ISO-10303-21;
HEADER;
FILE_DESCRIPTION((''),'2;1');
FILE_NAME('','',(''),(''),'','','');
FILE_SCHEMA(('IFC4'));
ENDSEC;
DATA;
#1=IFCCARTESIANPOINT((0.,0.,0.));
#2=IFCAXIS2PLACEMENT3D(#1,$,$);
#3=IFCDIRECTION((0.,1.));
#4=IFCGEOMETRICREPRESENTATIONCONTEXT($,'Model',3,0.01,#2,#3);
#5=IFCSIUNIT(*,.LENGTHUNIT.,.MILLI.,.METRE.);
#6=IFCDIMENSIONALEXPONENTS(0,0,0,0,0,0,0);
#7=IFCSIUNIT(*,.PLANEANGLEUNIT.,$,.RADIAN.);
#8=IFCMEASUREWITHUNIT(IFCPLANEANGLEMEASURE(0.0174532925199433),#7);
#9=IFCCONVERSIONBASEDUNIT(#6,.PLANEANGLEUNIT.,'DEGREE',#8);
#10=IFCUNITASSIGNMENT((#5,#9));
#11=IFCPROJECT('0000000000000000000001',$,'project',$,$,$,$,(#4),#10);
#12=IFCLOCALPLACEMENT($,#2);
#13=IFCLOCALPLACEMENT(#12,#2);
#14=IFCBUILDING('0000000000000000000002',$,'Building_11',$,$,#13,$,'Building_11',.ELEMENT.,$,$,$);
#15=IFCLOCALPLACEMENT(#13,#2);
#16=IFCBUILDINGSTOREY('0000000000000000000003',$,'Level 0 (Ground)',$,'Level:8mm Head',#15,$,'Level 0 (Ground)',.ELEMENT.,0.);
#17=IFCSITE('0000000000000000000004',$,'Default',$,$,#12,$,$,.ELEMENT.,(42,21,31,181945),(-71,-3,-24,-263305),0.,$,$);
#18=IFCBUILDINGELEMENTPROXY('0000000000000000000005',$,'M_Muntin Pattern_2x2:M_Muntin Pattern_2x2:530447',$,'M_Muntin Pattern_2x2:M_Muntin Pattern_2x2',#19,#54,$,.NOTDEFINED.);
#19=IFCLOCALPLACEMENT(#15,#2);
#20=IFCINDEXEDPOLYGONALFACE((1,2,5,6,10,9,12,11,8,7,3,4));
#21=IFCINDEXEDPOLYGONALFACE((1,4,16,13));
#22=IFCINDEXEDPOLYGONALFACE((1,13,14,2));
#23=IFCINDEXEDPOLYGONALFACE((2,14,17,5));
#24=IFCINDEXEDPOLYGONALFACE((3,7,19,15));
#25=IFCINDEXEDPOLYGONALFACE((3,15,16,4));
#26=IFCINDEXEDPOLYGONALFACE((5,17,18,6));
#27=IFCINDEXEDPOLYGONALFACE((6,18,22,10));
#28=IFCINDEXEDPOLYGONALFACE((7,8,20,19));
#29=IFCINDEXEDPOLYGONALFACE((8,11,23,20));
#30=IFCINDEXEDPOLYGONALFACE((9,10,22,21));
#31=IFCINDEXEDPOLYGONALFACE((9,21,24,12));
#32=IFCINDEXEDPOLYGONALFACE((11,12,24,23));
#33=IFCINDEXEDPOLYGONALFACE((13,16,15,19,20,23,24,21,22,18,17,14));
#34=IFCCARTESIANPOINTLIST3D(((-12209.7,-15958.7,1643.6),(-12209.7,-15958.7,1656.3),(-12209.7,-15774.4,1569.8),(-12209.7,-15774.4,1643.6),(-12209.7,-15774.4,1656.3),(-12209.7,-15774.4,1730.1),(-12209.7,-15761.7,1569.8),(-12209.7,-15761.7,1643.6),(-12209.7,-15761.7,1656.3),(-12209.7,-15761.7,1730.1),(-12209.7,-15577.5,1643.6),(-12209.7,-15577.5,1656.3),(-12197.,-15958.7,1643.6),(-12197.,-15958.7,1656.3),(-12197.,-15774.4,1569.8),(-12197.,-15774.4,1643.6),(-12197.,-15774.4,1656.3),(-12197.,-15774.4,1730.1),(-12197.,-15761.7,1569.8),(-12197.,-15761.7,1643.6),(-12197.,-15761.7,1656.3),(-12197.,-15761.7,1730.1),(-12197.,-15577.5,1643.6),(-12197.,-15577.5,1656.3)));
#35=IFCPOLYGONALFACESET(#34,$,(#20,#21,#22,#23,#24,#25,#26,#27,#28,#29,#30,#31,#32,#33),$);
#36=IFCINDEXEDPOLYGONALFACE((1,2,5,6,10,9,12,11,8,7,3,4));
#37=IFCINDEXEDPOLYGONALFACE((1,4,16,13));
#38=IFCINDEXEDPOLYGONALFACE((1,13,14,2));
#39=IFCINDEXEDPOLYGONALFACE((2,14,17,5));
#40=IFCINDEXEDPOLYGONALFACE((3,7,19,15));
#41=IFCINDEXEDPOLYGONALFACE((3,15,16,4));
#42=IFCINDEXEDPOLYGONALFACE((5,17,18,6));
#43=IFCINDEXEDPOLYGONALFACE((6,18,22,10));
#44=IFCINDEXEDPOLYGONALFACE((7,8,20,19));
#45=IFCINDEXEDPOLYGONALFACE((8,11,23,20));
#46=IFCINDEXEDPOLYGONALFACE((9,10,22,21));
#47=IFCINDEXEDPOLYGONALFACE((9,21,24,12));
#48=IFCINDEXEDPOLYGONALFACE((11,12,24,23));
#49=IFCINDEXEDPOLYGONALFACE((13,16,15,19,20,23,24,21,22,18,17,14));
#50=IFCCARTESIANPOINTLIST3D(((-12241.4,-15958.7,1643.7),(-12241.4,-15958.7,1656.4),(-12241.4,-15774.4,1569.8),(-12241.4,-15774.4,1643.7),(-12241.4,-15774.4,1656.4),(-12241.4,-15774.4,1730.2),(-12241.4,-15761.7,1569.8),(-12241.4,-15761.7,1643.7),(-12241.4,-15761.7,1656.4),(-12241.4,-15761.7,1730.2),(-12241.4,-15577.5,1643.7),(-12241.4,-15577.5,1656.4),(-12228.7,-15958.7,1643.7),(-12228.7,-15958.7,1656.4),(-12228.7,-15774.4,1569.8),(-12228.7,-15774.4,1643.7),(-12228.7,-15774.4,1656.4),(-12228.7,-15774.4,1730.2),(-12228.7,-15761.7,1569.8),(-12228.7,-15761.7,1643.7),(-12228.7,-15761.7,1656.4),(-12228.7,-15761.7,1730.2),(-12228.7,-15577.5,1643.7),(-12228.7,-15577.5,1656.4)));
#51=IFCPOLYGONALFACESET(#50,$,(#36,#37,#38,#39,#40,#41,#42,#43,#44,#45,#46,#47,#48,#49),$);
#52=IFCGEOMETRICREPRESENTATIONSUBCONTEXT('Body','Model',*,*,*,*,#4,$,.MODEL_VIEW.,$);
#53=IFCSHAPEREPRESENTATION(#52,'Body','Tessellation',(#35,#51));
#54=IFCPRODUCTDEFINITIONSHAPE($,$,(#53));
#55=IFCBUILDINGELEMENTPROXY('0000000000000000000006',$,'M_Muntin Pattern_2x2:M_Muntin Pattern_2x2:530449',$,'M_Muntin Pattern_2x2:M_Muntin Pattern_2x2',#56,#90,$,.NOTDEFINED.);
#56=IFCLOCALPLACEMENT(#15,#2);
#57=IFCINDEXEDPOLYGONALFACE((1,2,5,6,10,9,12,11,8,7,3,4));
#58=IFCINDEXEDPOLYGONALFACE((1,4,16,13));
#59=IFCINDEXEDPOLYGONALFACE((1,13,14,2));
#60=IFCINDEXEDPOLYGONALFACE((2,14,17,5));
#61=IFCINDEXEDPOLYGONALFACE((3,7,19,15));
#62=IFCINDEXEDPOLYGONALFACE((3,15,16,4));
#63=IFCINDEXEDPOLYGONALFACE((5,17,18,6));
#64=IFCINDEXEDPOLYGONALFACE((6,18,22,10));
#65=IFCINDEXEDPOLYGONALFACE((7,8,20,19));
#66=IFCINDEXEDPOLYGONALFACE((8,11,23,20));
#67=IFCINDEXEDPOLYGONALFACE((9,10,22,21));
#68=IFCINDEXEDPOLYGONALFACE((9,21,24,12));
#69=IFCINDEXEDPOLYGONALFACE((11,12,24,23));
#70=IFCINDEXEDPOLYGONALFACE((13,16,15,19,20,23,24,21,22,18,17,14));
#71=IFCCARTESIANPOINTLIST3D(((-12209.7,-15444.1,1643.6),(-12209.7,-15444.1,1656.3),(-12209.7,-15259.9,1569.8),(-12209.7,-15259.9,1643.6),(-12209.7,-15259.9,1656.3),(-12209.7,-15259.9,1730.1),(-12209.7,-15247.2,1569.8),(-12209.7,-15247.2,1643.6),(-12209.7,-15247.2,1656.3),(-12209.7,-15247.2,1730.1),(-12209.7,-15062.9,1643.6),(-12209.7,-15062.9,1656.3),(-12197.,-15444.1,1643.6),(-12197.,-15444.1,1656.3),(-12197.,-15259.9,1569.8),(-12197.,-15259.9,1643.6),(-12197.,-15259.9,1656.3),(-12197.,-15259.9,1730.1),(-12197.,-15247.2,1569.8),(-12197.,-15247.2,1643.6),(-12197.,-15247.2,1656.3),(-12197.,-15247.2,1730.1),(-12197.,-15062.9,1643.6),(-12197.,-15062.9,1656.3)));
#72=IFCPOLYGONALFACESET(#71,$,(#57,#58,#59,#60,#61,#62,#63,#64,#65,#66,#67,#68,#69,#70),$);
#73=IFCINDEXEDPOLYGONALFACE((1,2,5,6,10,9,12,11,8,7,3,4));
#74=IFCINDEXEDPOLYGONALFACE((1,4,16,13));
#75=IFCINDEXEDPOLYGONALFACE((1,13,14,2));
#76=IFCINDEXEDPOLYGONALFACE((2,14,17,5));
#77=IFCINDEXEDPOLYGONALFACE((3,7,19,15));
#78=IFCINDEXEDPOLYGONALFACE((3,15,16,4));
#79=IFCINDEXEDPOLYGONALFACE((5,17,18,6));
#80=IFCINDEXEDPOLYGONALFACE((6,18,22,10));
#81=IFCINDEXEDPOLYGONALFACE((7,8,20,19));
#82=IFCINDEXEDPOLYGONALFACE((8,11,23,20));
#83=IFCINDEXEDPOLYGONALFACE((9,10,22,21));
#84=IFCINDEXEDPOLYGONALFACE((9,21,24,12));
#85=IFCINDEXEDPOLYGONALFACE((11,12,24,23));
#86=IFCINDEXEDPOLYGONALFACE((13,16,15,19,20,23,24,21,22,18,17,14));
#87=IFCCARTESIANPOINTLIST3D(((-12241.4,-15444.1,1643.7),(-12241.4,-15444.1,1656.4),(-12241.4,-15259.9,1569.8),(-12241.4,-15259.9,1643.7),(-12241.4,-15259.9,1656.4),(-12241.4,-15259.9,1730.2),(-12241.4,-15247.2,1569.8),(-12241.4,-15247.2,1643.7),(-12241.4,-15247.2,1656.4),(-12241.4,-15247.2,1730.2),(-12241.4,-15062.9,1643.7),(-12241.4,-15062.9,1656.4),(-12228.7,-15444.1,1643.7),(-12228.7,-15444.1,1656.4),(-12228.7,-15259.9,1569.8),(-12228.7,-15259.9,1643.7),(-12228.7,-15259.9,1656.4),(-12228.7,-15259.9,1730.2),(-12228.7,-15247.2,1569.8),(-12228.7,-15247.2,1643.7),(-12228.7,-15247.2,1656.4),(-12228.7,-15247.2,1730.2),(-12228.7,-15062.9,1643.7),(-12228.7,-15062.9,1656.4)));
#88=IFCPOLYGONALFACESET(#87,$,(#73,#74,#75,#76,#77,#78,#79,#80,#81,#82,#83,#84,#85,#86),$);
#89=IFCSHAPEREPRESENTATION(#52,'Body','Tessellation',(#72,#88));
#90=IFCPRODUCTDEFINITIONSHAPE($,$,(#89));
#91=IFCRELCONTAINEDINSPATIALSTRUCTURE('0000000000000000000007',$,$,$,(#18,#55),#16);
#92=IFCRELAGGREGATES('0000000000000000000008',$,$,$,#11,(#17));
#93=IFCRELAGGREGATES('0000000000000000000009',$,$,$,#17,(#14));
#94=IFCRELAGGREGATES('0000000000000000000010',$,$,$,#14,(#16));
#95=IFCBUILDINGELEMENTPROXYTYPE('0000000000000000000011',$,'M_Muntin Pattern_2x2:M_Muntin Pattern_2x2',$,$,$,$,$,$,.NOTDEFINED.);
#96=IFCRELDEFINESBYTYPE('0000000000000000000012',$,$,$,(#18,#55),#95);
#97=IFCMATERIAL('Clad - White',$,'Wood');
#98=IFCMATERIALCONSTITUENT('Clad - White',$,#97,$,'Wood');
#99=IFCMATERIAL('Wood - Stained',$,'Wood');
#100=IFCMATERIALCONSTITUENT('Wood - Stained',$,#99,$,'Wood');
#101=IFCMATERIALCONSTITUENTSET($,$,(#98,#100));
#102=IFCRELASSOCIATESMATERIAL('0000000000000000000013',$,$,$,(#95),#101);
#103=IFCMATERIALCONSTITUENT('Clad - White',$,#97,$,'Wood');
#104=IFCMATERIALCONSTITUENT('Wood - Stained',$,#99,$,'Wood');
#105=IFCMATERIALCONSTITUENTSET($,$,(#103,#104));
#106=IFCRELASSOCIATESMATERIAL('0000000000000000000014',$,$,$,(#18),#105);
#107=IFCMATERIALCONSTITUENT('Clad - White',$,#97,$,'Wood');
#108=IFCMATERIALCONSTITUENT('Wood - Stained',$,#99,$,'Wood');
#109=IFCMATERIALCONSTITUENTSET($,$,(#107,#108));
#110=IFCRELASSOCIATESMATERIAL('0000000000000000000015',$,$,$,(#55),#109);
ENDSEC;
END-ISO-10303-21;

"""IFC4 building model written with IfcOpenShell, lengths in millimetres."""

from ifc_helpers import new_model, entity, si_unit, converted_unit, direction, frame, origin, place, context, subcontext, project, spatial, indexed_curve, outline, extrude, source, transform, mapped, material, constituent, constituent_set, type_object, type_shapes, element, save


model = new_model("IFC4")

# Units and contexts
model_context = context("Model", 3, precision=0.01, world=origin(), true_north=direction((0.0, 1.0)))
body_context = subcontext(model_context, "Body", "Model", "MODEL_VIEW")
ifc_project = project(units=[si_unit("LENGTHUNIT", "METRE", prefix="MILLI"), converted_unit("PLANEANGLEUNIT", "DEGREE", entity("IfcPlaneAngleMeasure", 0.0174532925199433), si_unit("PLANEANGLEUNIT", "RADIAN"), dimensions=[0, 0, 0, 0, 0, 0, 0])], contexts=[model_context])

# Site, building, storey
site_placement = place(None, origin())
site = spatial("IfcSite", under=ifc_project, at=site_placement, Name="Default", CompositionType="ELEMENT", RefLatitude=(42, 21, 31, 181945), RefLongitude=(-71, -3, -24, -263305), RefElevation=0.0)
building_placement = place(site_placement, origin())
building = spatial("IfcBuilding", under=site, at=building_placement, Name="Building_11", LongName="Building_11", CompositionType="ELEMENT")
storey_placement = place(building_placement, origin())
storey = spatial("IfcBuildingStorey", under=building, at=storey_placement, Name="Level 0 (Ground)", ObjectType="Level:8mm Head", LongName="Level 0 (Ground)", CompositionType="ELEMENT", Elevation=0.0)

# Building element proxies
ifc_material_1 = material(Name="Clad - White", Category="Wood")
ifc_material_2 = material(Name="Wood - Stained", Category="Wood")
ifc_constituent_1 = constituent(ifc_material_1, Name="Clad - White", Category="Wood")
ifc_constituent_2 = constituent(ifc_material_2, Name="Wood - Stained", Category="Wood")
ifc_constituent_set_1 = constituent_set(constituents=[ifc_constituent_1, ifc_constituent_2])
building_element_proxy_type_1 = type_object("IfcBuildingElementProxyType", Name="M_Muntin Pattern_2x2:M_Muntin Pattern_2x2", PredefinedType="NOTDEFINED", material=ifc_constituent_set_1)
shared_shape_1 = source(origin(), body_context, "Body", "SweptSolid", [
    extrude(outline(indexed_curve([(6.4, -6.4), (80.1, -6.4), (80.1, 6.3), (6.4, 6.3), (6.4, 190.6), (-6.3, 190.6), (-6.3, 6.3), (-80.2, 6.3), (-80.2, -6.4), (-6.3, -6.4), (-6.3, -190.6), (6.4, -190.6), (6.4, -6.4)], self_intersect=False)), frame((0.0, 9.5, 80.1), z_axis=(0.0, 1.0, 0.0), x_axis=(0.0, 0.0, 1.0)), (0.0, 0.0, 1.0), 12.7),
    extrude(outline(indexed_curve([(6.4, -6.4), (80.2, -6.4), (80.2, 6.3), (6.4, 6.3), (6.4, 190.6), (-6.3, 190.6), (-6.3, 6.3), (-80.2, 6.3), (-80.2, -6.4), (-6.3, -6.4), (-6.3, -190.6), (6.4, -190.6), (6.4, -6.4)], self_intersect=False)), frame((0.0, -22.2, 80.2), z_axis=(0.0, 1.0, 0.0), x_axis=(0.0, 0.0, 1.0)), (0.0, 0.0, 1.0), 12.7),
])
type_shapes(building_element_proxy_type_1, [shared_shape_1])
ifc_constituent_3 = constituent(ifc_material_1, Name="Clad - White", Category="Wood")
ifc_constituent_4 = constituent(ifc_material_2, Name="Wood - Stained", Category="Wood")
ifc_constituent_set_2 = constituent_set(constituents=[ifc_constituent_3, ifc_constituent_4])
proxy_1_placement = place(storey_placement, frame((-12219.2, -15768.1, 1569.8), z_axis=(0.0, 0.0, 1.0), x_axis=(0.0, -1.0, 0.0)))
element("IfcBuildingElementProxy", 1, at=proxy_1_placement, inside=storey, type_object=building_element_proxy_type_1, material=ifc_constituent_set_2, Name="M_Muntin Pattern_2x2:M_Muntin Pattern_2x2:530447", ObjectType="M_Muntin Pattern_2x2:M_Muntin Pattern_2x2", PredefinedType="NOTDEFINED", context=body_context, shape_type="MappedRepresentation", body=[
    mapped(shared_shape_1, transform((0.0, 0.0, 0.0), scale=1.0)),
])
ifc_constituent_5 = constituent(ifc_material_1, Name="Clad - White", Category="Wood")
ifc_constituent_6 = constituent(ifc_material_2, Name="Wood - Stained", Category="Wood")
ifc_constituent_set_3 = constituent_set(constituents=[ifc_constituent_5, ifc_constituent_6])
proxy_2_placement = place(storey_placement, frame((-12219.2, -15253.5, 1569.8), z_axis=(0.0, 0.0, 1.0), x_axis=(0.0, -1.0, 0.0)))
element("IfcBuildingElementProxy", 2, at=proxy_2_placement, inside=storey, type_object=building_element_proxy_type_1, material=ifc_constituent_set_3, Name="M_Muntin Pattern_2x2:M_Muntin Pattern_2x2:530449", ObjectType="M_Muntin Pattern_2x2:M_Muntin Pattern_2x2", PredefinedType="NOTDEFINED", context=body_context, shape_type="MappedRepresentation", body=[
    mapped(shared_shape_1, transform((0.0, 0.0, 0.0), scale=1.0)),
])

save(model, "model.ifc")
